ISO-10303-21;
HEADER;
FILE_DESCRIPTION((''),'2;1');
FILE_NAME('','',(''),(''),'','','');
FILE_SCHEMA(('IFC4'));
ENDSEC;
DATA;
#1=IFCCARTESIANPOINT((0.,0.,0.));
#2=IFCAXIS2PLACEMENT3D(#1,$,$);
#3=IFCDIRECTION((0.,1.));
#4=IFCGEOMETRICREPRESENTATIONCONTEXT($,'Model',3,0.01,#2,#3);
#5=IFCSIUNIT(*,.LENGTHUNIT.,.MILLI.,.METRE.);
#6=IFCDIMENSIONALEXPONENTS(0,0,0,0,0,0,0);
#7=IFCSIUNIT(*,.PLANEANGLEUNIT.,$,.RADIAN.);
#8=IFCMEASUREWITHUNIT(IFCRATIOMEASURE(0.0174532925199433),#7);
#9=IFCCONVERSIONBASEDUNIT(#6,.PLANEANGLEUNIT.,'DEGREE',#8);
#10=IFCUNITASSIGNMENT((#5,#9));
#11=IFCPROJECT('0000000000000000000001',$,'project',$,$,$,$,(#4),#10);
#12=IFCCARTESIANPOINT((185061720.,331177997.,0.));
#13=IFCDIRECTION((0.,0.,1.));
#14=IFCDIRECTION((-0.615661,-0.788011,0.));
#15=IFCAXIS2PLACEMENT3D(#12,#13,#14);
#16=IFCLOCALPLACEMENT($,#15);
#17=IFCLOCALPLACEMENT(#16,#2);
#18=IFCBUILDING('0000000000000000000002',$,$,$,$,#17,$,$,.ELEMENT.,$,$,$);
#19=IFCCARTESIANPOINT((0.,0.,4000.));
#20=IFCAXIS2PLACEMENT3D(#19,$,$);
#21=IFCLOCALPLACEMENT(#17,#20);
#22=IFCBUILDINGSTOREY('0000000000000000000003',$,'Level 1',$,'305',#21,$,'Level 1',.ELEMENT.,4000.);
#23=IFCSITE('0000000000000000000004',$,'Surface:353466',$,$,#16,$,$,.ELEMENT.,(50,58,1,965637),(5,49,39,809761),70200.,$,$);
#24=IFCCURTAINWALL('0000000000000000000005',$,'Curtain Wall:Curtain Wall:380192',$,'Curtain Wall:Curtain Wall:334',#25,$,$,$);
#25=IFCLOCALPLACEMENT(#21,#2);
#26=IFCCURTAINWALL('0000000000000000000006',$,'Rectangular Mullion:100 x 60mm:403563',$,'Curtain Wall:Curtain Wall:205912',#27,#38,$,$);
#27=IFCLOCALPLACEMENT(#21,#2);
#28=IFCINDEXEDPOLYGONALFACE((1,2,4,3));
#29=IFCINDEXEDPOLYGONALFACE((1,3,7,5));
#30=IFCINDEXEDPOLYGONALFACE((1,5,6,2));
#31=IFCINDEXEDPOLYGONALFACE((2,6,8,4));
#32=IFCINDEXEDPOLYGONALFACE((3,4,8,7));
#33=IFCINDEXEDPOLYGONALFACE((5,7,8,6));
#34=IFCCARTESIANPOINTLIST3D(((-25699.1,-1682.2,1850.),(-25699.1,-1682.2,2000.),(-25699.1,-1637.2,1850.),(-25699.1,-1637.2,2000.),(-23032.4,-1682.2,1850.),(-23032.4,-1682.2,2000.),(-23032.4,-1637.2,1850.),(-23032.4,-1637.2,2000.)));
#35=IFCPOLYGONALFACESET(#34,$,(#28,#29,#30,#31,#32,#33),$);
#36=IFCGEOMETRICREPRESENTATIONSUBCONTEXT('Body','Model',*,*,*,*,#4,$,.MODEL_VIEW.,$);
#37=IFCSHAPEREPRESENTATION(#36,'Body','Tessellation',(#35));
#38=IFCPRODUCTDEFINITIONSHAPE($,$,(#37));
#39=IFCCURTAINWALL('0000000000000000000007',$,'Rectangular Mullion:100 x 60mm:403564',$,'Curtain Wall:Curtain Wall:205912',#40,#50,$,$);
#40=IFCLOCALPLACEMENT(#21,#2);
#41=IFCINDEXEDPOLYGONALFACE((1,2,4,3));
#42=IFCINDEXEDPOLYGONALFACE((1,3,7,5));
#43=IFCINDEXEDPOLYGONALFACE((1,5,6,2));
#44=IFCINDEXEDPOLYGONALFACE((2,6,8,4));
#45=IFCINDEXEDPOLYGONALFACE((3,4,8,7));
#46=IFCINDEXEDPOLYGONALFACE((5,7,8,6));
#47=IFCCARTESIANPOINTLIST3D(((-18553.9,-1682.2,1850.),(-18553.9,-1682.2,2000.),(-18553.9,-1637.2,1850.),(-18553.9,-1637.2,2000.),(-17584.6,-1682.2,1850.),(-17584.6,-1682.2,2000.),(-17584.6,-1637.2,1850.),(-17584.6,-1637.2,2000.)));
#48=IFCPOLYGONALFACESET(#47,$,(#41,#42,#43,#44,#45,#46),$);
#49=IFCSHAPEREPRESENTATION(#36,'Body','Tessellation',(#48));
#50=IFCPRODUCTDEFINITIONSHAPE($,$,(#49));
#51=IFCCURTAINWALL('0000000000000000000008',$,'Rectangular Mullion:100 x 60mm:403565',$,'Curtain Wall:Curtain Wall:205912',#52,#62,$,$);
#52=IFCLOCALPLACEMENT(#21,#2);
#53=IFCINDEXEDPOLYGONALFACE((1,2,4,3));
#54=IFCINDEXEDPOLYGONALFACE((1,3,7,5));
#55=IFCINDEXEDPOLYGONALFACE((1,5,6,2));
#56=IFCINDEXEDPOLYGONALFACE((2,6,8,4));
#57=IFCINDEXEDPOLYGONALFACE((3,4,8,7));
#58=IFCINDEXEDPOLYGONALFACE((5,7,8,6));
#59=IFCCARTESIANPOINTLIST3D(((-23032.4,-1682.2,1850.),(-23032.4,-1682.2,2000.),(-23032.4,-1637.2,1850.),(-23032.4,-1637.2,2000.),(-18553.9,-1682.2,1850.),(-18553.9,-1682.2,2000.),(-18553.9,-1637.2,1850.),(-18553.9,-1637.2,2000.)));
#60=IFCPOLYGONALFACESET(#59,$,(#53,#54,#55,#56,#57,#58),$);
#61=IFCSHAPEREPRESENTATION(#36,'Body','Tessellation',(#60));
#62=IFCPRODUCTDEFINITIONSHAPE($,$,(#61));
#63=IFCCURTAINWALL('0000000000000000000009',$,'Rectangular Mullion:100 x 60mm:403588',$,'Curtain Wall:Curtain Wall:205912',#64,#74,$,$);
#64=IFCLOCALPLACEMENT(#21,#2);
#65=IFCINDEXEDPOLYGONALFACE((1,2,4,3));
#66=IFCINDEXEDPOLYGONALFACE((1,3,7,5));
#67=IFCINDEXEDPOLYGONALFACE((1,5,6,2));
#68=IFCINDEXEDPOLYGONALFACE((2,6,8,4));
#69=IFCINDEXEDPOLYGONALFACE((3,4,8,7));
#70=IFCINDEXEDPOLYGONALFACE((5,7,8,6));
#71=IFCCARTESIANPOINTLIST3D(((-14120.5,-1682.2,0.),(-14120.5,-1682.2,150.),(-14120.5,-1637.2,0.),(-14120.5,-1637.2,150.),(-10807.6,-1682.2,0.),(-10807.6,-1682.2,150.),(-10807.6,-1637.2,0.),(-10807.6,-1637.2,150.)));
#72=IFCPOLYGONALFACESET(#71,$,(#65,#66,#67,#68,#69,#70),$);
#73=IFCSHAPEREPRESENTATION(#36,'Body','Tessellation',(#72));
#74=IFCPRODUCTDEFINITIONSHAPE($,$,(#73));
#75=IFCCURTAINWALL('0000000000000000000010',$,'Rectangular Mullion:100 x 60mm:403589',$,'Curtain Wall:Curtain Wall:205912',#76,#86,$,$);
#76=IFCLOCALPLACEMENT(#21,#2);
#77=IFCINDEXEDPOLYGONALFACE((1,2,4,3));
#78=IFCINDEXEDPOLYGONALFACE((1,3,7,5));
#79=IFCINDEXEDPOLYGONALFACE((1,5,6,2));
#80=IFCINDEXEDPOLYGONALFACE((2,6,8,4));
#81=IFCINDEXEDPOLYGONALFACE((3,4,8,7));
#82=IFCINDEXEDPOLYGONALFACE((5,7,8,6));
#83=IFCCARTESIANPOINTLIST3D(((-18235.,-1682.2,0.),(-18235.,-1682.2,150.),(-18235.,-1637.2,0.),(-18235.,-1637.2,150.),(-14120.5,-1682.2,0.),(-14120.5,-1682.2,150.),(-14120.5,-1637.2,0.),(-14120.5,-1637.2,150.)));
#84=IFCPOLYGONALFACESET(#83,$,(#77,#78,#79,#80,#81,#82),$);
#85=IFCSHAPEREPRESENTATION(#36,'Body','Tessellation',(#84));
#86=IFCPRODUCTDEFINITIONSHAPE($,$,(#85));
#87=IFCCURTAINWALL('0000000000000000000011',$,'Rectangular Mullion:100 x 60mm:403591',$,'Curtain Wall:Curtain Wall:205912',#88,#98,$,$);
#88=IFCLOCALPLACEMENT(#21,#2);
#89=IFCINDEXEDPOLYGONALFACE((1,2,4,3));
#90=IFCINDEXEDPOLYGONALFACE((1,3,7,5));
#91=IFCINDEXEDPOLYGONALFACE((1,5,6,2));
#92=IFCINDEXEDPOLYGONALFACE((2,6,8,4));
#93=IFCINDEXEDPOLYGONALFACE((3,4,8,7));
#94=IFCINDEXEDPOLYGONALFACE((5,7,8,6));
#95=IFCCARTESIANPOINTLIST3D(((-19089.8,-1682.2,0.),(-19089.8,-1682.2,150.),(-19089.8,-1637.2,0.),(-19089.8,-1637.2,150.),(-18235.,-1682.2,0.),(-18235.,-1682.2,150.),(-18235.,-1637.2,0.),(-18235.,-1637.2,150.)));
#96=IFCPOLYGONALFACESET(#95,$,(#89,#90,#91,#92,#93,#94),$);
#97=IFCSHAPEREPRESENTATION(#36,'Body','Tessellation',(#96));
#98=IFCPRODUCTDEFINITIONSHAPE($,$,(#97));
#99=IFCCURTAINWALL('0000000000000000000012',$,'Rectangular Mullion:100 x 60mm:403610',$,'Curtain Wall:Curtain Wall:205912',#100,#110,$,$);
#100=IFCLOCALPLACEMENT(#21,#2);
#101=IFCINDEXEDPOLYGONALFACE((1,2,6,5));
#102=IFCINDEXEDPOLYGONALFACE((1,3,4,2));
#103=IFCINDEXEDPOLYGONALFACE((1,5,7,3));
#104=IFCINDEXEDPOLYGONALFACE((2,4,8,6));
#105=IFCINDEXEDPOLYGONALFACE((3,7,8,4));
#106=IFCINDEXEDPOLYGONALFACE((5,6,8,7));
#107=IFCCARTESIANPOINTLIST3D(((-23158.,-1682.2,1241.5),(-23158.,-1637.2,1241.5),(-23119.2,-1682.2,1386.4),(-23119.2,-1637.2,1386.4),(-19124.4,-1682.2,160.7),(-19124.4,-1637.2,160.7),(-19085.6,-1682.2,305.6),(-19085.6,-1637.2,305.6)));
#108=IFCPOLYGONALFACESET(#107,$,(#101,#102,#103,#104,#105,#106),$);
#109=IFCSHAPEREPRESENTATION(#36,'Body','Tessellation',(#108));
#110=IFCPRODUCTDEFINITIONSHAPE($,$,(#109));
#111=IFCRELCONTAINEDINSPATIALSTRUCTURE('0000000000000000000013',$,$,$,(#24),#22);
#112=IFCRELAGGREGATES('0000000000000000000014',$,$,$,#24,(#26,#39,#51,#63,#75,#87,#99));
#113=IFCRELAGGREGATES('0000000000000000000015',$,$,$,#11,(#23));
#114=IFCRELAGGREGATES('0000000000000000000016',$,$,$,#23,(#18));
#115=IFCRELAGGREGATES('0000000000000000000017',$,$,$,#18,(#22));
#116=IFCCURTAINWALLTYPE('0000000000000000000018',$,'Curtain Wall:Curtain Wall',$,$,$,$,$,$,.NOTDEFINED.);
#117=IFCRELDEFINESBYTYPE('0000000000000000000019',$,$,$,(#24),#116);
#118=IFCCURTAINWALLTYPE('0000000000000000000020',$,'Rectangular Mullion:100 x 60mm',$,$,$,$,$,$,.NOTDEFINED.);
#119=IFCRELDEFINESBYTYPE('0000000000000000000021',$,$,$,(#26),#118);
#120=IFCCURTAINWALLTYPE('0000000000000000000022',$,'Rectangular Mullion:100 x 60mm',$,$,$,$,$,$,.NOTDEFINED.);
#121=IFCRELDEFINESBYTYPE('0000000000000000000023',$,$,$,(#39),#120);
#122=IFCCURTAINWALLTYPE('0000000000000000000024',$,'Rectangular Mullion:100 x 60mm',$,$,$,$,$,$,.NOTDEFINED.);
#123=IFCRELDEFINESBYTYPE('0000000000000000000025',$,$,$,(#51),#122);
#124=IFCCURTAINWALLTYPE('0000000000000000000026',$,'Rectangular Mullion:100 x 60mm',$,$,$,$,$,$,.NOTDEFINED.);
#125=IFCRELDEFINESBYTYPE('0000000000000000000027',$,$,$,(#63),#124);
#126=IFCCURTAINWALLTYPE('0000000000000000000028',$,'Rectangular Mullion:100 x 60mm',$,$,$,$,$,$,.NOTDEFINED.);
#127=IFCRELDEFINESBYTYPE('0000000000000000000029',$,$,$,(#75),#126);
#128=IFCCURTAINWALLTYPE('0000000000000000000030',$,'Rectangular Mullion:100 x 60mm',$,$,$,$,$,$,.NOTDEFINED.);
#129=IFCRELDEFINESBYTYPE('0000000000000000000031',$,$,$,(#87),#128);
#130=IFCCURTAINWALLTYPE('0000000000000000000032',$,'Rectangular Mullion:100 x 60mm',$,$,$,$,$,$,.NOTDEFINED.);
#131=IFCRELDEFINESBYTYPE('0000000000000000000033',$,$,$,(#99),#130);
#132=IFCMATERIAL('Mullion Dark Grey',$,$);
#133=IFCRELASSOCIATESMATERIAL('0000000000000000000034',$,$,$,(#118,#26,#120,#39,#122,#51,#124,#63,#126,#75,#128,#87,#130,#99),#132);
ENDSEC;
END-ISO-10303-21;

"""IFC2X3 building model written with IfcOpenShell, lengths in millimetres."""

from ifc_helpers import new_model, entity, si_unit, converted_unit, direction, frame, frame_2d, origin, place, context, subcontext, project, spatial, rectangle, extrude, source, transform, mapped, material, type_object, type_shapes, element, aggregate, save


model = new_model("IFC2X3")

# Units and contexts
model_context = context("Model", 3, precision=0.01, world=origin(), true_north=direction((0.0, 1.0)))
body_context = subcontext(model_context, "Body", "Model", "MODEL_VIEW")
ifc_project = project(units=[si_unit("LENGTHUNIT", "METRE", prefix="MILLI"), converted_unit("PLANEANGLEUNIT", "DEGREE", entity("IfcRatioMeasure", 0.0174532925199433), si_unit("PLANEANGLEUNIT", "RADIAN"), dimensions=[0, 0, 0, 0, 0, 0, 0])], contexts=[model_context])

# Site, building, storey
site_placement = place(None, frame((185061720.0, 331177997.0, 0.0), z_axis=(0.0, 0.0, 1.0), x_axis=(-0.615661, -0.788011, 0.0)))
site = spatial("IfcSite", under=ifc_project, at=site_placement, Name="Surface:353466", CompositionType="ELEMENT", RefLatitude=(50, 58, 1, 965637), RefLongitude=(5, 49, 39, 809761), RefElevation=70200.0)
building_placement = place(site_placement, origin())
building = spatial("IfcBuilding", under=site, at=building_placement, CompositionType="ELEMENT")
storey_placement = place(building_placement, frame((0.0, 0.0, 4000.0)))
storey = spatial("IfcBuildingStorey", under=building, at=storey_placement, Name="Level 1", ObjectType="305", LongName="Level 1", CompositionType="ELEMENT", Elevation=4000.0)

# Curtain walls
curtain_wall_type_1 = type_object("IfcCurtainWallType", Name="Curtain Wall:Curtain Wall", PredefinedType="NOTDEFINED")
curtain_wall_1_placement = place(storey_placement, frame((0.0, 0.0, -4000.0)))
curtain_wall_1 = element("IfcCurtainWall", 1, at=curtain_wall_1_placement, inside=storey, type_object=curtain_wall_type_1, Name="Curtain Wall:Curtain Wall:380192", ObjectType="Curtain Wall:Curtain Wall:334")
ifc_material_1 = material(Name="Mullion Dark Grey")
curtain_wall_type_2 = type_object("IfcCurtainWallType", Name="Rectangular Mullion:100 x 60mm", PredefinedType="NOTDEFINED", material=ifc_material_1)
shared_shape_1 = source(origin(), body_context, "Body", "SweptSolid", [
    extrude(rectangle(XDim=45.0, YDim=150.0, at=frame_2d((0.0, 0.0), x_axis=(1.0, 0.0))), frame((-75.0, 7.5, -2666.7), z_axis=(0.0, 0.0, 1.0), x_axis=(0.0, -1.0, 0.0)), (0.0, 0.0, 1.0), 2666.7),
])
type_shapes(curtain_wall_type_2, [shared_shape_1])
curtain_wall_2_placement = place(storey_placement, frame((-23032.4, -1652.2, 2000.0), z_axis=(1.0, 0.0, 0.0), x_axis=(0.0, 0.0, 1.0)))
curtain_wall_2 = element("IfcCurtainWall", 2, at=curtain_wall_2_placement, type_object=curtain_wall_type_2, material=ifc_material_1, Name="Rectangular Mullion:100 x 60mm:403563", ObjectType="Curtain Wall:Curtain Wall:205912", context=body_context, shape_type="MappedRepresentation", body=[
    mapped(shared_shape_1, transform((0.0, 0.0, 0.0), scale=1.0)),
])
curtain_wall_type_3 = type_object("IfcCurtainWallType", Name="Rectangular Mullion:100 x 60mm", PredefinedType="NOTDEFINED", material=ifc_material_1)
shared_shape_2 = source(origin(), body_context, "Body", "SweptSolid", [
    extrude(rectangle(XDim=45.0, YDim=150.0, at=frame_2d((0.0, 0.0), x_axis=(1.0, 0.0))), frame((-75.0, 7.5, -969.3), z_axis=(0.0, 0.0, 1.0), x_axis=(0.0, -1.0, 0.0)), (0.0, 0.0, 1.0), 969.3),
])
type_shapes(curtain_wall_type_3, [shared_shape_2])
curtain_wall_3_placement = place(storey_placement, frame((-17584.6, -1652.2, 2000.0), z_axis=(1.0, 0.0, 0.0), x_axis=(0.0, 0.0, 1.0)))
curtain_wall_3 = element("IfcCurtainWall", 3, at=curtain_wall_3_placement, type_object=curtain_wall_type_3, material=ifc_material_1, Name="Rectangular Mullion:100 x 60mm:403564", ObjectType="Curtain Wall:Curtain Wall:205912", context=body_context, shape_type="MappedRepresentation", body=[
    mapped(shared_shape_2, transform((0.0, 0.0, 0.0), scale=1.0)),
])
curtain_wall_type_4 = type_object("IfcCurtainWallType", Name="Rectangular Mullion:100 x 60mm", PredefinedType="NOTDEFINED", material=ifc_material_1)
shared_shape_3 = source(origin(), body_context, "Body", "SweptSolid", [
    extrude(rectangle(XDim=45.0, YDim=150.0, at=frame_2d((0.0, 0.0), x_axis=(1.0, 0.0))), frame((-75.0, 7.5, -4478.5), z_axis=(0.0, 0.0, 1.0), x_axis=(0.0, -1.0, 0.0)), (0.0, 0.0, 1.0), 4478.5),
])
type_shapes(curtain_wall_type_4, [shared_shape_3])
curtain_wall_4_placement = place(storey_placement, frame((-18553.9, -1652.2, 2000.0), z_axis=(1.0, 0.0, 0.0), x_axis=(0.0, 0.0, 1.0)))
curtain_wall_4 = element("IfcCurtainWall", 4, at=curtain_wall_4_placement, type_object=curtain_wall_type_4, material=ifc_material_1, Name="Rectangular Mullion:100 x 60mm:403565", ObjectType="Curtain Wall:Curtain Wall:205912", context=body_context, shape_type="MappedRepresentation", body=[
    mapped(shared_shape_3, transform((0.0, 0.0, 0.0), scale=1.0)),
])
curtain_wall_type_5 = type_object("IfcCurtainWallType", Name="Rectangular Mullion:100 x 60mm", PredefinedType="NOTDEFINED", material=ifc_material_1)
shared_shape_4 = source(origin(), body_context, "Body", "SweptSolid", [
    extrude(rectangle(XDim=150.0, YDim=45.0, at=frame_2d((0.0, 0.0), x_axis=(1.0, 0.0))), frame((-75.0, 7.5, -3312.9), z_axis=(0.0, 0.0, 1.0), x_axis=(-1.0, 0.0, 0.0)), (0.0, 0.0, 1.0), 3312.9),
])
type_shapes(curtain_wall_type_5, [shared_shape_4])
curtain_wall_5_placement = place(storey_placement, frame((-14120.5, -1652.2, 0.0), z_axis=(-1.0, 0.0, 0.0), x_axis=(0.0, 0.0, -1.0)))
curtain_wall_5 = element("IfcCurtainWall", 5, at=curtain_wall_5_placement, type_object=curtain_wall_type_5, material=ifc_material_1, Name="Rectangular Mullion:100 x 60mm:403588", ObjectType="Curtain Wall:Curtain Wall:205912", context=body_context, shape_type="MappedRepresentation", body=[
    mapped(shared_shape_4, transform((0.0, 0.0, 0.0), scale=1.0)),
])
curtain_wall_type_6 = type_object("IfcCurtainWallType", Name="Rectangular Mullion:100 x 60mm", PredefinedType="NOTDEFINED", material=ifc_material_1)
shared_shape_5 = source(origin(), body_context, "Body", "SweptSolid", [
    extrude(rectangle(XDim=150.0, YDim=45.0, at=frame_2d((0.0, 0.0), x_axis=(1.0, 0.0))), frame((-75.0, 7.5, -4114.5), z_axis=(0.0, 0.0, 1.0), x_axis=(-1.0, 0.0, 0.0)), (0.0, 0.0, 1.0), 4114.5),
])
type_shapes(curtain_wall_type_6, [shared_shape_5])
curtain_wall_6_placement = place(storey_placement, frame((-18235.0, -1652.2, 0.0), z_axis=(-1.0, 0.0, 0.0), x_axis=(0.0, 0.0, -1.0)))
curtain_wall_6 = element("IfcCurtainWall", 6, at=curtain_wall_6_placement, type_object=curtain_wall_type_6, material=ifc_material_1, Name="Rectangular Mullion:100 x 60mm:403589", ObjectType="Curtain Wall:Curtain Wall:205912", context=body_context, shape_type="MappedRepresentation", body=[
    mapped(shared_shape_5, transform((0.0, 0.0, 0.0), scale=1.0)),
])
curtain_wall_type_7 = type_object("IfcCurtainWallType", Name="Rectangular Mullion:100 x 60mm", PredefinedType="NOTDEFINED", material=ifc_material_1)
shared_shape_6 = source(origin(), body_context, "Body", "SweptSolid", [
    extrude(rectangle(XDim=150.0, YDim=45.0, at=frame_2d((0.0, 0.0), x_axis=(1.0, 0.0))), frame((-75.0, 7.5, -854.8), z_axis=(0.0, 0.0, 1.0), x_axis=(-1.0, 0.0, 0.0)), (0.0, 0.0, 1.0), 854.8),
])
type_shapes(curtain_wall_type_7, [shared_shape_6])
curtain_wall_7_placement = place(storey_placement, frame((-19089.8, -1652.2, 0.0), z_axis=(-1.0, 0.0, 0.0), x_axis=(0.0, 0.0, -1.0)))
curtain_wall_7 = element("IfcCurtainWall", 7, at=curtain_wall_7_placement, type_object=curtain_wall_type_7, material=ifc_material_1, Name="Rectangular Mullion:100 x 60mm:403591", ObjectType="Curtain Wall:Curtain Wall:205912", context=body_context, shape_type="MappedRepresentation", body=[
    mapped(shared_shape_6, transform((0.0, 0.0, 0.0), scale=1.0)),
])
curtain_wall_type_8 = type_object("IfcCurtainWallType", Name="Rectangular Mullion:100 x 60mm", PredefinedType="NOTDEFINED", material=ifc_material_1)
shared_shape_7 = source(origin(), body_context, "Body", "SweptSolid", [
    extrude(rectangle(XDim=45.0, YDim=150.0, at=frame_2d((0.0, 0.0), x_axis=(1.0, 0.0))), frame((0.0, 7.5, -4175.9), z_axis=(0.0, 0.0, 1.0), x_axis=(0.0, -1.0, 0.0)), (0.0, 0.0, 1.0), 4175.9),
])
type_shapes(curtain_wall_type_8, [shared_shape_7])
curtain_wall_8_placement = place(storey_placement, frame((-19105.0, -1652.2, 233.1), z_axis=(0.965926, 0.0, -0.258819), x_axis=(0.258819, 0.0, 0.965926)))
curtain_wall_8 = element("IfcCurtainWall", 8, at=curtain_wall_8_placement, type_object=curtain_wall_type_8, material=ifc_material_1, Name="Rectangular Mullion:100 x 60mm:403610", ObjectType="Curtain Wall:Curtain Wall:205912", context=body_context, shape_type="MappedRepresentation", body=[
    mapped(shared_shape_7, transform((0.0, 0.0, 0.0), scale=1.0)),
])
aggregate(curtain_wall_1, [curtain_wall_2, curtain_wall_3, curtain_wall_4, curtain_wall_5, curtain_wall_6, curtain_wall_7, curtain_wall_8])

save(model, "model.ifc")
